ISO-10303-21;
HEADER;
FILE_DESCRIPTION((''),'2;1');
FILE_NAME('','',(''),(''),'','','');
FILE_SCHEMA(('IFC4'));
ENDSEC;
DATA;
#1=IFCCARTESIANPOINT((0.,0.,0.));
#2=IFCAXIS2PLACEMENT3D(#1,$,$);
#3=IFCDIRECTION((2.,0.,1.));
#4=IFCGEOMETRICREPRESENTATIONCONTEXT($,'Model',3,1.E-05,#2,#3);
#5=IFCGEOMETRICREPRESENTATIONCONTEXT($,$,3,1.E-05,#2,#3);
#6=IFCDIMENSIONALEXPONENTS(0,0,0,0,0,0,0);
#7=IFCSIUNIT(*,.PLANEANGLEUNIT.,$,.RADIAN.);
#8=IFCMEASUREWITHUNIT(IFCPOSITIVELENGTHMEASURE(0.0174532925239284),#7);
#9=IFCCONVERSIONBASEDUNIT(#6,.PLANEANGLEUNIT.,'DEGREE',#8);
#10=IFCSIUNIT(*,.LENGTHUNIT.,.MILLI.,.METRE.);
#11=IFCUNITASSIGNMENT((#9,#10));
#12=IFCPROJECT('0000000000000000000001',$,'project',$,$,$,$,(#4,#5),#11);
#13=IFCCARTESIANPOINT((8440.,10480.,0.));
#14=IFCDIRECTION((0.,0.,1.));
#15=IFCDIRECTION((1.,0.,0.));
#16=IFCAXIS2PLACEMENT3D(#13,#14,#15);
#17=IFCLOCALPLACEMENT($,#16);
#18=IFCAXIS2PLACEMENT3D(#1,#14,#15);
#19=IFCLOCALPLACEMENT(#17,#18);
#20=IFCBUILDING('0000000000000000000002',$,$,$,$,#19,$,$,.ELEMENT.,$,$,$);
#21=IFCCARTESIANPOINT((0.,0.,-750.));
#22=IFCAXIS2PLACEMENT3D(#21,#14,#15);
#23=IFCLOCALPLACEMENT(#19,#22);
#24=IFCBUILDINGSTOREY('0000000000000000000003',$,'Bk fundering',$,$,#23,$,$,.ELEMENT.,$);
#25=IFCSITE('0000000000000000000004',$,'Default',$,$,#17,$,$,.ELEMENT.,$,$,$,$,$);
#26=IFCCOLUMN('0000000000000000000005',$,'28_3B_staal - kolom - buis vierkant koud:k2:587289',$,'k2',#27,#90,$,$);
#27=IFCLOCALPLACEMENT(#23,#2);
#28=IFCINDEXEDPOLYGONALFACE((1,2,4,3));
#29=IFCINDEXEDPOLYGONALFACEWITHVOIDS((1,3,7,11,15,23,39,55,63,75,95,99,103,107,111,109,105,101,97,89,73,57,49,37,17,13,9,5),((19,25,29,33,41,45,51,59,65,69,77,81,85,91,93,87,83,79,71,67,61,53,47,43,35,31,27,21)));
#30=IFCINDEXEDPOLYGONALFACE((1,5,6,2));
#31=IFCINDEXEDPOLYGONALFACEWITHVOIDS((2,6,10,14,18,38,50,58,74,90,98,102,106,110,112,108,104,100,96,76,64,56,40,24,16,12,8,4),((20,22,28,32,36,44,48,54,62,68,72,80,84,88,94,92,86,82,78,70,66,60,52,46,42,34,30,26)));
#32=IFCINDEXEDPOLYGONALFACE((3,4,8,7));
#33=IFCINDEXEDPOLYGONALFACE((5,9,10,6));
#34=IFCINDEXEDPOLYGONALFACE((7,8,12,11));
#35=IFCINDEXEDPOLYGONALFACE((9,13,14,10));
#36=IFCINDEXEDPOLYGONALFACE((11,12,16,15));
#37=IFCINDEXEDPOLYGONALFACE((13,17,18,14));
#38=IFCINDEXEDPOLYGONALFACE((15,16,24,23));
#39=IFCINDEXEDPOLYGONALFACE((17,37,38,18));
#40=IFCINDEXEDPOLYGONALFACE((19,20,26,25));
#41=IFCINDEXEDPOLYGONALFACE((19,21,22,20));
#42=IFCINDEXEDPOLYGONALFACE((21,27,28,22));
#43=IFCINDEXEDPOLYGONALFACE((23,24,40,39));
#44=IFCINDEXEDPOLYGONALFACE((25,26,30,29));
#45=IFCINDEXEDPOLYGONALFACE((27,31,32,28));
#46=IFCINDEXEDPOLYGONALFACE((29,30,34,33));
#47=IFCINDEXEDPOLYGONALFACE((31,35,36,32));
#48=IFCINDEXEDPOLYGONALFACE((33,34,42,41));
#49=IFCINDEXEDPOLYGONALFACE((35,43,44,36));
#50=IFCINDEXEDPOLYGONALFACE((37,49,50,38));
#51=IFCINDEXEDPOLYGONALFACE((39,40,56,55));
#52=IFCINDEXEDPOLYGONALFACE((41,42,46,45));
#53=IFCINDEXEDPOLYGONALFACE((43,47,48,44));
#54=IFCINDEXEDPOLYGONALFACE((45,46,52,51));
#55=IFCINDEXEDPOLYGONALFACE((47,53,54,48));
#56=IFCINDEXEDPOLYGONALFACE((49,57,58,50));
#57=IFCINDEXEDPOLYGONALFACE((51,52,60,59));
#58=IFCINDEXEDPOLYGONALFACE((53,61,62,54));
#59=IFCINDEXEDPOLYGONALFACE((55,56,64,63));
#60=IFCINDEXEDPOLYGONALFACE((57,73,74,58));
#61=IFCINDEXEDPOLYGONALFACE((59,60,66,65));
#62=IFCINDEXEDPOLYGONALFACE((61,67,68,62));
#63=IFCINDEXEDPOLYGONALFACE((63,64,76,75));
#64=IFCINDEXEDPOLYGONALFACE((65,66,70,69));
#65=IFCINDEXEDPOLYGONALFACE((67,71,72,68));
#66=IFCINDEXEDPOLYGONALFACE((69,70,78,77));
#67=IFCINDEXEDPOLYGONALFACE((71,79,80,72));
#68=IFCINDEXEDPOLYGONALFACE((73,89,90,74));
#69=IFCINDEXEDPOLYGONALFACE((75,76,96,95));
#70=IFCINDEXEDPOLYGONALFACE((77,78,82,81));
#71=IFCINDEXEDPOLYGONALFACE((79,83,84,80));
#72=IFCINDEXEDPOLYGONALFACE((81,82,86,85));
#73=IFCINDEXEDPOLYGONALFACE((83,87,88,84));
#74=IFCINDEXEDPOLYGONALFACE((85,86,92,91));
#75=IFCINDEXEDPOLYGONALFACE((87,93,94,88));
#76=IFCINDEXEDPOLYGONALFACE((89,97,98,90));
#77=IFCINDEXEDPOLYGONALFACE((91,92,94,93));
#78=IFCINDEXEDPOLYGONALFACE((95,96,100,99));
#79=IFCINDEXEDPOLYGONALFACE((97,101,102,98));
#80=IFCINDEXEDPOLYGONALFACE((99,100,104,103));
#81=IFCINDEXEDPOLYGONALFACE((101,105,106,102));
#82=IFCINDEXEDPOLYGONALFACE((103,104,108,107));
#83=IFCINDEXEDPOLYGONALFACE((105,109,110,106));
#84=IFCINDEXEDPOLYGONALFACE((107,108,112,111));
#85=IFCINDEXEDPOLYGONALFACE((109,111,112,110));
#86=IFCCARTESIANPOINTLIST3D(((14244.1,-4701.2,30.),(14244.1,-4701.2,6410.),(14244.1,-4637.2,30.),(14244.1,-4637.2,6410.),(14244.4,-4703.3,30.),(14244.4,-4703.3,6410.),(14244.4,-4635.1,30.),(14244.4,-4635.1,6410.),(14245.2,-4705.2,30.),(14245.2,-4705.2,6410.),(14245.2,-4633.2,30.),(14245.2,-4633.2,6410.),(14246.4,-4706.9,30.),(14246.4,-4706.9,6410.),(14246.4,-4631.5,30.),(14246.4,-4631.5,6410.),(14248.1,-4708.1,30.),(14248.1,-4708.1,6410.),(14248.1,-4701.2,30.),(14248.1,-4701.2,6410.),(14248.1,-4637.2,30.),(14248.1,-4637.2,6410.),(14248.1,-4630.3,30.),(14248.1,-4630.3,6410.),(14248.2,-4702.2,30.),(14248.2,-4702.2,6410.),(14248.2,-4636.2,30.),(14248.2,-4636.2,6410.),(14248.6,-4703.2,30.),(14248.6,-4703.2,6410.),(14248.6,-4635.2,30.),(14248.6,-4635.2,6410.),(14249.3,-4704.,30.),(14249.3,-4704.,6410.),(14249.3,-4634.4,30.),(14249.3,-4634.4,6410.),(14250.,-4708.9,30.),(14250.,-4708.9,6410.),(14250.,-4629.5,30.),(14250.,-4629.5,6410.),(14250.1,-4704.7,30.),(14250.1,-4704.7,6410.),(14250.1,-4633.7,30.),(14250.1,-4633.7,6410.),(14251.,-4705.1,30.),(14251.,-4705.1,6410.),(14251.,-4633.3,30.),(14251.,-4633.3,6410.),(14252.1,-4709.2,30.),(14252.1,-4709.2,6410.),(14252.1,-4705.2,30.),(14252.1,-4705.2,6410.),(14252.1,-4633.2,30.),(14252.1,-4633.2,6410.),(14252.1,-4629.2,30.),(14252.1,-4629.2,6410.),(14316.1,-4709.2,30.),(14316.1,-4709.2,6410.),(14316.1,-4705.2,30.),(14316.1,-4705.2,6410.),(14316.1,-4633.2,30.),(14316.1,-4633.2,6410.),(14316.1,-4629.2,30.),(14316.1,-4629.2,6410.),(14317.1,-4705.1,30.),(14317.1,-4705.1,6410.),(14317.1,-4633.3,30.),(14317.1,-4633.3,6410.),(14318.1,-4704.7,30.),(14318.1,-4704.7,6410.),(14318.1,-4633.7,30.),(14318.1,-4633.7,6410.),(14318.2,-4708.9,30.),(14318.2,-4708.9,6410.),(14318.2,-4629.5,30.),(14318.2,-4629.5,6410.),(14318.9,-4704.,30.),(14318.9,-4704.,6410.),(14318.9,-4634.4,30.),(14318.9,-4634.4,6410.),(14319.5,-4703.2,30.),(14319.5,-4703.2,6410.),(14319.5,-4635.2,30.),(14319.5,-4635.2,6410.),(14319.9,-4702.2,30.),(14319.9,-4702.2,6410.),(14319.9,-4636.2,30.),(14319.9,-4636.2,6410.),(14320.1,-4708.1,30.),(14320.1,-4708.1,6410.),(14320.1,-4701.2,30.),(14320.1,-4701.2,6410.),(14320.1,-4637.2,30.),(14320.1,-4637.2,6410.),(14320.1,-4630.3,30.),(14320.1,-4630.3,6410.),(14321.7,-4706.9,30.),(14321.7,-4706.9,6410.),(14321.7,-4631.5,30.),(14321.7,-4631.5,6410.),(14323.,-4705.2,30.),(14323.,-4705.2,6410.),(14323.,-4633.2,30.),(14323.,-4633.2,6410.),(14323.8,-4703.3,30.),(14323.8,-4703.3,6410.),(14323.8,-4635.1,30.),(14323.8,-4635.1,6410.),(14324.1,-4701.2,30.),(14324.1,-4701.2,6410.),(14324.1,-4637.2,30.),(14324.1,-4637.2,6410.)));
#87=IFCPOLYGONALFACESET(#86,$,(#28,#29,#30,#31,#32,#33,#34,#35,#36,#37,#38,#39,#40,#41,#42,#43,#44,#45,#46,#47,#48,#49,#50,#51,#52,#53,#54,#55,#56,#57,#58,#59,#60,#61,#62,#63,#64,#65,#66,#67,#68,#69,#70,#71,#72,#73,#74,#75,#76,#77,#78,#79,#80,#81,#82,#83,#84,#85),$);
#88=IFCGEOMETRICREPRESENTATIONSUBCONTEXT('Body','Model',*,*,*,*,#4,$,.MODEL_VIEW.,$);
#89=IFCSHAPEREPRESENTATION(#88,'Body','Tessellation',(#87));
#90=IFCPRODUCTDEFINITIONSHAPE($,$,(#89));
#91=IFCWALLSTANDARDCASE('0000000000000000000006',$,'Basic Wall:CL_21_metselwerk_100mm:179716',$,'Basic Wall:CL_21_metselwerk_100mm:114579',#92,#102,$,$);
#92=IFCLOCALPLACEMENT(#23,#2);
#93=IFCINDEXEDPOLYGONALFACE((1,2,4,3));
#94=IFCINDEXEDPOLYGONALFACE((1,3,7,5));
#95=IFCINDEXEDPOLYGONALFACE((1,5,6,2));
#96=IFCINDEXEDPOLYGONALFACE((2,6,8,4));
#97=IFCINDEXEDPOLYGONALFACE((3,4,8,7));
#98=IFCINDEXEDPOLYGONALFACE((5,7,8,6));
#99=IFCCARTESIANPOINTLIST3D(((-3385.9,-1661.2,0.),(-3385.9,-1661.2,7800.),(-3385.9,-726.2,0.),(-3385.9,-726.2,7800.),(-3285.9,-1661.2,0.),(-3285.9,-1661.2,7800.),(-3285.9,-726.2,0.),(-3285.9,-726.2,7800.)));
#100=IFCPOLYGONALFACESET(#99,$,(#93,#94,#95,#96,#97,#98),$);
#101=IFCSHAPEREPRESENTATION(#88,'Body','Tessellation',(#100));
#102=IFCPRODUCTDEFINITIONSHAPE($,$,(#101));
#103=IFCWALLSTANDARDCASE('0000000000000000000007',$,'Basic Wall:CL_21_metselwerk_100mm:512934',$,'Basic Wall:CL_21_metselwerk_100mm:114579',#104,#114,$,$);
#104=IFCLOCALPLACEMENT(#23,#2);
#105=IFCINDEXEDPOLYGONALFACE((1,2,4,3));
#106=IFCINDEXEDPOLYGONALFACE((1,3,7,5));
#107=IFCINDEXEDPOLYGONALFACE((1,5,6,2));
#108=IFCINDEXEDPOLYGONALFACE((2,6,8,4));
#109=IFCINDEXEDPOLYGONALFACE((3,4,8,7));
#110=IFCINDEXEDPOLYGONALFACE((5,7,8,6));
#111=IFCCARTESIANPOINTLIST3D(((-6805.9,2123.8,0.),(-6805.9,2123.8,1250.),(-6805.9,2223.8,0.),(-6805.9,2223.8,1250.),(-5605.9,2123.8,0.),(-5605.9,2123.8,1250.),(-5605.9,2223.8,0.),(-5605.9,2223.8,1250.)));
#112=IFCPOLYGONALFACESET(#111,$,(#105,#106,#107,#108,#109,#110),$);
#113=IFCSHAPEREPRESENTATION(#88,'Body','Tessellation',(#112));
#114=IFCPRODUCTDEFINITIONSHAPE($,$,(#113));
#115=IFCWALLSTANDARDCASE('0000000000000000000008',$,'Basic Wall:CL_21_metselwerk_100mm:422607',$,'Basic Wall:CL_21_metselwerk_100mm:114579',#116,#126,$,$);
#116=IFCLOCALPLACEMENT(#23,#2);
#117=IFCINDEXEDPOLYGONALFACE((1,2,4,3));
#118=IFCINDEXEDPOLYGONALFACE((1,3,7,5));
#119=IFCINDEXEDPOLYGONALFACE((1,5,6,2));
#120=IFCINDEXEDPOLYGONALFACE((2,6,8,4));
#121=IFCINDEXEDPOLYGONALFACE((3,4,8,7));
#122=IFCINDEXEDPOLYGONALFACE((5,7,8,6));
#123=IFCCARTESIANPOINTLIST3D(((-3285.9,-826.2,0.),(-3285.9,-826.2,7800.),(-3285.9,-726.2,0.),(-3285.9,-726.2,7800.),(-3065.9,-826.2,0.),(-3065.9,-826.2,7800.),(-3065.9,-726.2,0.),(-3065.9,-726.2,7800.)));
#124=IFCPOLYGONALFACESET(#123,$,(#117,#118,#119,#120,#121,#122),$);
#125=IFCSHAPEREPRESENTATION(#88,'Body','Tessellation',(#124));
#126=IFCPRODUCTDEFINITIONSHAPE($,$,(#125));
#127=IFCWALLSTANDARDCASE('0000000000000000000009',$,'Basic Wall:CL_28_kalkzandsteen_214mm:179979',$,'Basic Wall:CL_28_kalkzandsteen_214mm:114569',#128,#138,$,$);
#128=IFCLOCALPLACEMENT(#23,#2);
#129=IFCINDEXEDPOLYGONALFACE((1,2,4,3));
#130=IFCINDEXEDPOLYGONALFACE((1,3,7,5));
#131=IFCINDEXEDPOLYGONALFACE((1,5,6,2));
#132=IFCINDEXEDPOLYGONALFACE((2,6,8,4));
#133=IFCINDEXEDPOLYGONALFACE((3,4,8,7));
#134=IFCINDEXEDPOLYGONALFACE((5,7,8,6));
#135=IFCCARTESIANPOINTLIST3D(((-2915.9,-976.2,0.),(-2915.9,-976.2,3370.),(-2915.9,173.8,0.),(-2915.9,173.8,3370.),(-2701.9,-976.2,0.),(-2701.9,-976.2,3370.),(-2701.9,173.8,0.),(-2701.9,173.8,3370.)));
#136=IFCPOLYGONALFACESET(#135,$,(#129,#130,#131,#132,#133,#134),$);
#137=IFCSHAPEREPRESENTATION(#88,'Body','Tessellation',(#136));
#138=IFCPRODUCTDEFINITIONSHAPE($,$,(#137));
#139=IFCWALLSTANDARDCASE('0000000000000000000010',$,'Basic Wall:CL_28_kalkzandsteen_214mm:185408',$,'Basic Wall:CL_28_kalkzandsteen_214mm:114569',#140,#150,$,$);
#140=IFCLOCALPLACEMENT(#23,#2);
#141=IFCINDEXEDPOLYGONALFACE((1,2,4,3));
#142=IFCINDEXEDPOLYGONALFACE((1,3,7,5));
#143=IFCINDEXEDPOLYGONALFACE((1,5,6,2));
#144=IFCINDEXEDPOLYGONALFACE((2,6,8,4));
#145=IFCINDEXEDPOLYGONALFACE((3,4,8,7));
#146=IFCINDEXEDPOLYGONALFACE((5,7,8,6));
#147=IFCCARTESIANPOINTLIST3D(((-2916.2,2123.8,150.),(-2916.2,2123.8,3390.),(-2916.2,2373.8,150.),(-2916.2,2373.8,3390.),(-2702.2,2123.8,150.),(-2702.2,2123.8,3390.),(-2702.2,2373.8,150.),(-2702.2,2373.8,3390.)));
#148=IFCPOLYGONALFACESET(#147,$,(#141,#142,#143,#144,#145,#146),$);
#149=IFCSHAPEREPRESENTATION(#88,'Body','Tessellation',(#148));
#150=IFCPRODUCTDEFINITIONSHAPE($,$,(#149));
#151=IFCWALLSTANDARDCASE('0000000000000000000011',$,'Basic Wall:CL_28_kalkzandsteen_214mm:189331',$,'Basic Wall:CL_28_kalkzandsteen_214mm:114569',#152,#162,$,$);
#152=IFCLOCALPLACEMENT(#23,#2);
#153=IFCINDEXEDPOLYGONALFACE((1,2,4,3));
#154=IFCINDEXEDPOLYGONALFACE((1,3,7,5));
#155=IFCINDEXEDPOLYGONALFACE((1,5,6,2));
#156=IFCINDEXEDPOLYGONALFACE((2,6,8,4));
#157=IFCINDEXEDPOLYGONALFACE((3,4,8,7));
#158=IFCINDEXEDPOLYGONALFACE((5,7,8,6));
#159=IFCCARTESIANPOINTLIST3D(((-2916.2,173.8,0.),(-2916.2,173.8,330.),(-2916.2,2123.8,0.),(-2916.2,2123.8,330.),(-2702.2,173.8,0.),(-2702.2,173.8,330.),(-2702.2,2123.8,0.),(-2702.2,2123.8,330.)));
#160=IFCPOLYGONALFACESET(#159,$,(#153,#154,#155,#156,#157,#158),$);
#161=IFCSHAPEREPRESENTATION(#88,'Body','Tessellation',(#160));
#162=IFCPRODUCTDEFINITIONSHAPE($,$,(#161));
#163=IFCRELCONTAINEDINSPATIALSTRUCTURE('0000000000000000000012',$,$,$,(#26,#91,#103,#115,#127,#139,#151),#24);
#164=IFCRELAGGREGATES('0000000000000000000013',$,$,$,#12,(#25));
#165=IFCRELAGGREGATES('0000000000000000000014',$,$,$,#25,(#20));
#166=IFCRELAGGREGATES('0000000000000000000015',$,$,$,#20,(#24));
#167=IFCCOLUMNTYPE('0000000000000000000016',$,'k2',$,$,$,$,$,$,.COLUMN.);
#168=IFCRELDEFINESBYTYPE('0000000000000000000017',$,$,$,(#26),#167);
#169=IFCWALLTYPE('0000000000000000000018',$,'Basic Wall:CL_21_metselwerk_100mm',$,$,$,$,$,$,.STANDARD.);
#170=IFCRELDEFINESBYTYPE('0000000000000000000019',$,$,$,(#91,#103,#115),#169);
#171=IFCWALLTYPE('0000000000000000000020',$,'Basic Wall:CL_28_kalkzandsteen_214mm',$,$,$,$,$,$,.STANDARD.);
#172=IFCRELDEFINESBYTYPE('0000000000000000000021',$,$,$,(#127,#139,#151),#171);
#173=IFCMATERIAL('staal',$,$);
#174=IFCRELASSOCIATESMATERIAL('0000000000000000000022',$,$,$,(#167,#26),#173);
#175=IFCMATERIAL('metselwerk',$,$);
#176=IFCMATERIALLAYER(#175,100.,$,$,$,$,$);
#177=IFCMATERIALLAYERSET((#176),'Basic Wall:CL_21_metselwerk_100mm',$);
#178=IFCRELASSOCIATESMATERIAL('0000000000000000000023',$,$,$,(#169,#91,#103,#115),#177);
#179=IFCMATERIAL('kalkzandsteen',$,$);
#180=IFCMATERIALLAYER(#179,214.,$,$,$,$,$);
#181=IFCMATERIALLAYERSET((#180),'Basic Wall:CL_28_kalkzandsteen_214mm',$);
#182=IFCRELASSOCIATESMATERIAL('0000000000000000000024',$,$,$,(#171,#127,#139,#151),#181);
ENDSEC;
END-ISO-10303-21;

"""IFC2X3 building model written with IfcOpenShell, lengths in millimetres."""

from ifc_helpers import new_model, entity, si_unit, converted_unit, direction, frame, frame_2d, origin, origin_with_axes, place, context, subcontext, project, spatial, polyline, circle_curve, parameter, trimmed, segment, composite_curve, rectangle, outline, extrude, clip, bounded_halfspace, source, transform, mapped, material, layer, layer_set, layer_usage, type_object, element, save


model = new_model("IFC2X3")

# Units and contexts
model_context = context("Model", 3, precision=1e-05, world=origin(), true_north=direction((2.0, 0.0, 1.0)))
context_of_model = context(None, 3, precision=1e-05, world=origin(), true_north=direction((2.0, 0.0, 1.0)))
body_context = subcontext(model_context, "Body", "Model", "MODEL_VIEW")
ifc_project = project(units=[converted_unit("PLANEANGLEUNIT", "DEGREE", entity("IfcPositiveLengthMeasure", 0.0174532925239284), si_unit("PLANEANGLEUNIT", "RADIAN"), dimensions=[0, 0, 0, 0, 0, 0, 0]), si_unit("LENGTHUNIT", "METRE", prefix="MILLI")], contexts=[model_context, context_of_model])

# Site, building, storey
site_placement = place(None, frame((8440.0, 10480.0, 0.0), z_axis=(0.0, 0.0, 1.0), x_axis=(1.0, 0.0, 0.0)))
site = spatial("IfcSite", under=ifc_project, at=site_placement, Name="Default", CompositionType="ELEMENT")
building_placement = place(site_placement, origin_with_axes())
building = spatial("IfcBuilding", under=site, at=building_placement, CompositionType="ELEMENT")
storey_placement = place(building_placement, frame((0.0, 0.0, -750.0), z_axis=(0.0, 0.0, 1.0), x_axis=(1.0, 0.0, 0.0)))
storey = spatial("IfcBuildingStorey", under=building, at=storey_placement, Name="Bk fundering", CompositionType="ELEMENT")

# Column
ifc_material_1 = material(Name="staal")
column_type_1 = type_object("IfcColumnType", Name="k2", PredefinedType="COLUMN", material=ifc_material_1)
shared_shape_1 = source(origin(), body_context, "Body", "SweptSolid", [
    extrude(outline(composite_curve([segment(polyline([(-32.0, -40.0), (32.0, -40.0)]), True, "CONTINUOUS"), segment(trimmed(circle_curve(frame_2d((32.0, -32.0), x_axis=(-1.0, 0.0)), 8.0), [parameter(90.0)], [parameter(180.0)], True, "PARAMETER"), True, "CONTINUOUS"), segment(polyline([(40.0, -32.0), (40.0, 32.0)]), True, "CONTINUOUS"), segment(trimmed(circle_curve(frame_2d((32.0, 32.0), x_axis=(-1.0, 0.0)), 8.0), [parameter(180.0)], [parameter(270.0)], True, "PARAMETER"), True, "CONTINUOUS"), segment(polyline([(32.0, 40.0), (-32.0, 40.0)]), True, "CONTINUOUS"), segment(trimmed(circle_curve(frame_2d((-32.0, 32.0), x_axis=(-1.0, 0.0)), 8.0), [parameter(270.0)], [parameter(360.0)], True, "PARAMETER"), True, "CONTINUOUS"), segment(polyline([(-40.0, 32.0), (-40.0, -32.0)]), True, "CONTINUOUS"), segment(trimmed(circle_curve(frame_2d((-32.0, -32.0), x_axis=(-1.0, 0.0)), 8.0), [parameter(360.0)], [parameter(90.0)], True, "PARAMETER"), True, "CONTINUOUS")], self_intersect=False), holes=[composite_curve([segment(trimmed(circle_curve(frame_2d((-32.0, -32.0), x_axis=(-1.0, 0.0)), 4.0), [parameter(0.0)], [parameter(90.0)], True, "PARAMETER"), False, "CONTINUOUS"), segment(polyline([(-36.0, -32.0), (-36.0, 32.0)]), True, "CONTINUOUS"), segment(trimmed(circle_curve(frame_2d((-32.0, 32.0), x_axis=(-1.0, 0.0)), 4.0), [parameter(270.0)], [parameter(0.0)], True, "PARAMETER"), False, "CONTINUOUS"), segment(polyline([(-32.0, 36.0), (32.0, 36.0)]), True, "CONTINUOUS"), segment(trimmed(circle_curve(frame_2d((32.0, 32.0), x_axis=(-1.0, 0.0)), 4.0), [parameter(180.0)], [parameter(270.0)], True, "PARAMETER"), False, "CONTINUOUS"), segment(polyline([(36.0, 32.0), (36.0, -32.0)]), True, "CONTINUOUS"), segment(trimmed(circle_curve(frame_2d((32.0, -32.0), x_axis=(-1.0, 0.0)), 4.0), [parameter(90.0)], [parameter(180.0)], True, "PARAMETER"), False, "CONTINUOUS"), segment(polyline([(32.0, -36.0), (-32.0, -36.0)]), True, "CONTINUOUS")], self_intersect=False)]), frame((14284.1, -4669.2, -720.0)), (0.0, 0.0, 1.0), 6380.0),
])
column_1_placement = place(storey_placement, frame((0.0, 0.0, 750.0), z_axis=(0.0, 0.0, 1.0), x_axis=(1.0, 0.0, 0.0)))
element("IfcColumn", 1, at=column_1_placement, inside=storey, type_object=column_type_1, material=ifc_material_1, Name="28_3B_staal - kolom - buis vierkant koud:k2:587289", ObjectType="k2", context=body_context, shape_type="MappedRepresentation", body=[
    mapped(shared_shape_1, transform((0.0, 0.0, 0.0), scale=1.0)),
])

# Walls
ifc_material_2 = material(Name="metselwerk")
ifc_layer_1 = layer(ifc_material_2, 100.0)
ifc_layer_set_1 = layer_set([ifc_layer_1], Name="Basic Wall:CL_21_metselwerk_100mm")
ifc_layer_usage_1 = layer_usage(ifc_layer_set_1, "AXIS2", "NEGATIVE", 50.0)
wall_type_1 = type_object("IfcWallType", Name="Basic Wall:CL_21_metselwerk_100mm", PredefinedType="STANDARD", material=ifc_layer_set_1)
shared_shape_2 = source(origin(), body_context, "Body", "SweptSolid", [
    extrude(rectangle(XDim=935.0, YDim=100.0, at=frame_2d((467.5, 0.0), x_axis=(-1.0, 0.0))), origin(), (0.0, 0.0, 1.0), 7800.0),
])
wall_1_placement = place(storey_placement, frame((-3335.9, -726.2, 0.0), z_axis=(0.0, 0.0, 1.0), x_axis=(0.0, -1.0, 0.0)))
element("IfcWallStandardCase", 2, at=wall_1_placement, inside=storey, type_object=wall_type_1, material=ifc_layer_usage_1, Name="Basic Wall:CL_21_metselwerk_100mm:179716", ObjectType="Basic Wall:CL_21_metselwerk_100mm:114579", context=body_context, shape_type="MappedRepresentation", body=[
    mapped(shared_shape_2, transform((0.0, 0.0, 0.0))),
])
ifc_layer_usage_2 = layer_usage(ifc_layer_set_1, "AXIS2", "NEGATIVE", 50.0)
shared_shape_3 = source(origin(), body_context, "Body", "SweptSolid", [
    extrude(rectangle(XDim=1200.0, YDim=100.0, at=frame_2d((600.0, 0.0), x_axis=(-1.0, 0.0))), origin(), (0.0, 0.0, 1.0), 1250.0),
])
wall_2_placement = place(storey_placement, frame((-6805.9, 2173.8, 0.0), z_axis=(0.0, 0.0, 1.0), x_axis=(1.0, 0.0, 0.0)))
element("IfcWallStandardCase", 3, at=wall_2_placement, inside=storey, type_object=wall_type_1, material=ifc_layer_usage_2, Name="Basic Wall:CL_21_metselwerk_100mm:512934", ObjectType="Basic Wall:CL_21_metselwerk_100mm:114579", context=body_context, shape_type="MappedRepresentation", body=[
    mapped(shared_shape_3, transform((0.0, 0.0, 0.0))),
])
ifc_layer_usage_3 = layer_usage(ifc_layer_set_1, "AXIS2", "NEGATIVE", 50.0)
shared_shape_4 = source(origin(), body_context, "Body", "SweptSolid", [
    extrude(rectangle(XDim=220.0, YDim=100.0, at=frame_2d((110.0, 0.0), x_axis=(-1.0, 0.0))), origin(), (0.0, 0.0, 1.0), 7800.0),
])
wall_3_placement = place(storey_placement, frame((-3065.9, -776.2, 0.0), z_axis=(0.0, 0.0, 1.0), x_axis=(-1.0, 0.0, 0.0)))
element("IfcWallStandardCase", 4, at=wall_3_placement, inside=storey, type_object=wall_type_1, material=ifc_layer_usage_3, Name="Basic Wall:CL_21_metselwerk_100mm:422607", ObjectType="Basic Wall:CL_21_metselwerk_100mm:114579", context=body_context, shape_type="MappedRepresentation", body=[
    mapped(shared_shape_4, transform((0.0, 0.0, 0.0))),
])
ifc_material_3 = material(Name="kalkzandsteen")
ifc_layer_2 = layer(ifc_material_3, 214.0)
ifc_layer_set_2 = layer_set([ifc_layer_2], Name="Basic Wall:CL_28_kalkzandsteen_214mm")
ifc_layer_usage_4 = layer_usage(ifc_layer_set_2, "AXIS2", "NEGATIVE", 107.0)
wall_type_2 = type_object("IfcWallType", Name="Basic Wall:CL_28_kalkzandsteen_214mm", PredefinedType="STANDARD", material=ifc_layer_set_2)
wall_4_placement = place(storey_placement, frame((-2808.9, 173.8, 0.0), z_axis=(0.0, 0.0, 1.0), x_axis=(0.0, -1.0, 0.0)))
element("IfcWallStandardCase", 5, at=wall_4_placement, inside=storey, type_object=wall_type_2, material=ifc_layer_usage_4, Name="Basic Wall:CL_28_kalkzandsteen_214mm:179979", ObjectType="Basic Wall:CL_28_kalkzandsteen_214mm:114569", context=body_context, shape_type="Clipping", body=[
    clip(extrude(rectangle(XDim=1150.0, YDim=214.0, at=frame_2d((575.0, 0.0), x_axis=(-1.0, 0.0))), origin(), (0.0, 0.0, 1.0), 3370.0), bounded_halfspace(frame((0.0, -107.0, 3370.0), z_axis=(0.0, 0.0, -1.0), x_axis=(0.0, 1.0, 0.0)), True, frame((0.0, -107.0, 3370.0)), polyline([(0.0, 0.0), (1150.0, 0.0), (1150.0, 214.0), (300.0, 214.0), (0.0, 214.0), (0.0, 0.0)]))),
])
ifc_layer_usage_5 = layer_usage(ifc_layer_set_2, "AXIS2", "NEGATIVE", 107.0)
wall_5_placement = place(storey_placement, frame((-2809.2, 2373.8, 150.0), z_axis=(0.0, 0.0, 1.0), x_axis=(0.0, -1.0, 0.0)))
element("IfcWallStandardCase", 6, at=wall_5_placement, inside=storey, type_object=wall_type_2, material=ifc_layer_usage_5, Name="Basic Wall:CL_28_kalkzandsteen_214mm:185408", ObjectType="Basic Wall:CL_28_kalkzandsteen_214mm:114569", context=body_context, shape_type="SweptSolid", body=[
    extrude(rectangle(XDim=250.0, YDim=214.0, at=frame_2d((125.0, 0.0), x_axis=(-1.0, 0.0))), origin(), (0.0, 0.0, 1.0), 3240.0),
])
ifc_layer_usage_6 = layer_usage(ifc_layer_set_2, "AXIS2", "NEGATIVE", 107.0)
wall_6_placement = place(storey_placement, frame((-2809.2, 2123.8, 0.0), z_axis=(0.0, 0.0, 1.0), x_axis=(0.0, -1.0, 0.0)))
element("IfcWallStandardCase", 7, at=wall_6_placement, inside=storey, type_object=wall_type_2, material=ifc_layer_usage_6, Name="Basic Wall:CL_28_kalkzandsteen_214mm:189331", ObjectType="Basic Wall:CL_28_kalkzandsteen_214mm:114569", context=body_context, shape_type="SweptSolid", body=[
    extrude(rectangle(XDim=1950.0, YDim=214.0, at=frame_2d((975.0, 0.0), x_axis=(-1.0, 0.0))), origin(), (0.0, 0.0, 1.0), 330.0),
])

save(model, "model.ifc")
